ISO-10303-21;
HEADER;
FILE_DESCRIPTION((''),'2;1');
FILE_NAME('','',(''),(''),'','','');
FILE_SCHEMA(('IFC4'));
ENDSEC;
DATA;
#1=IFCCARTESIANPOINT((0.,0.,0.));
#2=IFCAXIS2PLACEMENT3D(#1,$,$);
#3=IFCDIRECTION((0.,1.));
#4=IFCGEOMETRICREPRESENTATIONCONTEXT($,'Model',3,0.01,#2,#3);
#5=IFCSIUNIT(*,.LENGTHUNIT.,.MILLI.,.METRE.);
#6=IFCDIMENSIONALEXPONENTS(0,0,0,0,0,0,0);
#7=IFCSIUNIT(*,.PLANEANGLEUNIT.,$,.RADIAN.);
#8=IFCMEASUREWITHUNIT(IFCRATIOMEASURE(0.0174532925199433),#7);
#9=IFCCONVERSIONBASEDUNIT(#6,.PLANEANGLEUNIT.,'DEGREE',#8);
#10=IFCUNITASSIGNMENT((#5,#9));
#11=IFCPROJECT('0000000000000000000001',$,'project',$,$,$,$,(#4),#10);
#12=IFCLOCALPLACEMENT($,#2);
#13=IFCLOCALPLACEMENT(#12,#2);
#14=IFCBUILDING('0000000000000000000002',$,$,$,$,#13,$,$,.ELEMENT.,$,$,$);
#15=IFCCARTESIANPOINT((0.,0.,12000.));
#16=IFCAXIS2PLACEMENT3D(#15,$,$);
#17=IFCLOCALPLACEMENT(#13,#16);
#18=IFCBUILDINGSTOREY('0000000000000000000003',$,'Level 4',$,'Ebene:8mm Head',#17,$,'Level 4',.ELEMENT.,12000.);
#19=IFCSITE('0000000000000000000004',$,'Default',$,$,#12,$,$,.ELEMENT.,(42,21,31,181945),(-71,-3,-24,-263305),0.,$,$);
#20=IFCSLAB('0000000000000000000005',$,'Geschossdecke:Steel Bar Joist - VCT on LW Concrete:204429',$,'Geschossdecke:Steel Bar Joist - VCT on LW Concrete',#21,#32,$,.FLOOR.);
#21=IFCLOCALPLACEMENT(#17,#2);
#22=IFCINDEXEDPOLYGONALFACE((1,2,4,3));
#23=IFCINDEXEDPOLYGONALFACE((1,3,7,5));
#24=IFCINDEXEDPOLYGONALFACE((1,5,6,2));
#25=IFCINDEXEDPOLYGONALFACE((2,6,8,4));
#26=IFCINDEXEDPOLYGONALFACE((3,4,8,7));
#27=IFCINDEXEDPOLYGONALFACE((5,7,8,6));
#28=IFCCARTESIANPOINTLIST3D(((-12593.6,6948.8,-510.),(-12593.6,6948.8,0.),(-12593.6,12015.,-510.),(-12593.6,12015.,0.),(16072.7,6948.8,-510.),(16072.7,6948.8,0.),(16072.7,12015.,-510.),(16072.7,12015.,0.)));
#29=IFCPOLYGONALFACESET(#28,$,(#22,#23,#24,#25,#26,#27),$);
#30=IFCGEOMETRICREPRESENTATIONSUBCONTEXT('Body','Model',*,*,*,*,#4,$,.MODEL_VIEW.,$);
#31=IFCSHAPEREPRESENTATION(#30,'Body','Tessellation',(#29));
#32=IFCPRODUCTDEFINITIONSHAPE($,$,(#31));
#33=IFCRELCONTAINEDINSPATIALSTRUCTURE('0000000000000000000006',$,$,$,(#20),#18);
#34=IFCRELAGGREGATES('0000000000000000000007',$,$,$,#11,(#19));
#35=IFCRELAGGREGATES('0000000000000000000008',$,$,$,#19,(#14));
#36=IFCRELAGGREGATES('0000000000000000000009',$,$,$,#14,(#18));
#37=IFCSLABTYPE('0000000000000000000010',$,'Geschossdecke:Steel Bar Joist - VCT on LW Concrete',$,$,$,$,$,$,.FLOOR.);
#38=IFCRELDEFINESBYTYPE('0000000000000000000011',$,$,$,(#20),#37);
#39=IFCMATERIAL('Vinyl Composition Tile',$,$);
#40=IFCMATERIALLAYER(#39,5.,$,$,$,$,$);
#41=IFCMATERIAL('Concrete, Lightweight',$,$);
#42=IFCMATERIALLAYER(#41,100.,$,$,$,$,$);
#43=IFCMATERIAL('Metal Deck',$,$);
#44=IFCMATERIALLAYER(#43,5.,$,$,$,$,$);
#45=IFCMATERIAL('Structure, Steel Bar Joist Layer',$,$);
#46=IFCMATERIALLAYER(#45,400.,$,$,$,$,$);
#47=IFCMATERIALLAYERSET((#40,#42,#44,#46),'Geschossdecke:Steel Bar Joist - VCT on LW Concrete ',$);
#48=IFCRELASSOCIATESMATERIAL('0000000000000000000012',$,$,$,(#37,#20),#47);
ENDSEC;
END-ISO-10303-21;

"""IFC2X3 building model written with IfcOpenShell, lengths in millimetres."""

from ifc_helpers import new_model, entity, si_unit, converted_unit, direction, frame, frame_2d, origin, place, context, subcontext, project, spatial, rectangle, extrude, material, layer, layer_set, layer_usage, type_object, element, save


model = new_model("IFC2X3")

# Units and contexts
model_context = context("Model", 3, precision=0.01, world=origin(), true_north=direction((0.0, 1.0)))
body_context = subcontext(model_context, "Body", "Model", "MODEL_VIEW")
ifc_project = project(units=[si_unit("LENGTHUNIT", "METRE", prefix="MILLI"), converted_unit("PLANEANGLEUNIT", "DEGREE", entity("IfcRatioMeasure", 0.0174532925199433), si_unit("PLANEANGLEUNIT", "RADIAN"), dimensions=[0, 0, 0, 0, 0, 0, 0])], contexts=[model_context])

# Site, building, storey
site_placement = place(None, origin())
site = spatial("IfcSite", under=ifc_project, at=site_placement, Name="Default", CompositionType="ELEMENT", RefLatitude=(42, 21, 31, 181945), RefLongitude=(-71, -3, -24, -263305), RefElevation=0.0)
building_placement = place(site_placement, origin())
building = spatial("IfcBuilding", under=site, at=building_placement, CompositionType="ELEMENT")
storey_placement = place(building_placement, frame((0.0, 0.0, 12000.0)))
storey = spatial("IfcBuildingStorey", under=building, at=storey_placement, Name="Level 4", ObjectType="Ebene:8mm Head", LongName="Level 4", CompositionType="ELEMENT", Elevation=12000.0)

# Slab
ifc_material_1 = material(Name="Vinyl Composition Tile")
ifc_layer_1 = layer(ifc_material_1, 5.0)
ifc_material_2 = material(Name="Concrete, Lightweight")
ifc_layer_2 = layer(ifc_material_2, 100.0)
ifc_material_3 = material(Name="Metal Deck")
ifc_layer_3 = layer(ifc_material_3, 5.0)
ifc_material_4 = material(Name="Structure, Steel Bar Joist Layer")
ifc_layer_4 = layer(ifc_material_4, 400.0)
ifc_layer_set = layer_set([ifc_layer_1, ifc_layer_2, ifc_layer_3, ifc_layer_4], Name="Geschossdecke:Steel Bar Joist - VCT on LW Concrete ")
ifc_layer_usage = layer_usage(ifc_layer_set, "AXIS3", "POSITIVE", 0.0)
slab_type = type_object("IfcSlabType", Name="Geschossdecke:Steel Bar Joist - VCT on LW Concrete", PredefinedType="FLOOR", material=ifc_layer_set)
slab_placement = place(storey_placement, origin())
element("IfcSlab", 1, at=slab_placement, inside=storey, type_object=slab_type, material=ifc_layer_usage, Name="Geschossdecke:Steel Bar Joist - VCT on LW Concrete:204429", ObjectType="Geschossdecke:Steel Bar Joist - VCT on LW Concrete", PredefinedType="FLOOR", context=body_context, shape_type="SweptSolid", body=[
    extrude(rectangle(XDim=5066.3, YDim=28666.3, at=frame_2d((0.0, 0.0), x_axis=(1.0, 0.0))), frame((1739.6, 9481.9, 0.0), z_axis=(0.0, 0.0, -1.0), x_axis=(0.0, 1.0, 0.0)), (0.0, 0.0, 1.0), 510.0),
])

save(model, "model.ifc")
